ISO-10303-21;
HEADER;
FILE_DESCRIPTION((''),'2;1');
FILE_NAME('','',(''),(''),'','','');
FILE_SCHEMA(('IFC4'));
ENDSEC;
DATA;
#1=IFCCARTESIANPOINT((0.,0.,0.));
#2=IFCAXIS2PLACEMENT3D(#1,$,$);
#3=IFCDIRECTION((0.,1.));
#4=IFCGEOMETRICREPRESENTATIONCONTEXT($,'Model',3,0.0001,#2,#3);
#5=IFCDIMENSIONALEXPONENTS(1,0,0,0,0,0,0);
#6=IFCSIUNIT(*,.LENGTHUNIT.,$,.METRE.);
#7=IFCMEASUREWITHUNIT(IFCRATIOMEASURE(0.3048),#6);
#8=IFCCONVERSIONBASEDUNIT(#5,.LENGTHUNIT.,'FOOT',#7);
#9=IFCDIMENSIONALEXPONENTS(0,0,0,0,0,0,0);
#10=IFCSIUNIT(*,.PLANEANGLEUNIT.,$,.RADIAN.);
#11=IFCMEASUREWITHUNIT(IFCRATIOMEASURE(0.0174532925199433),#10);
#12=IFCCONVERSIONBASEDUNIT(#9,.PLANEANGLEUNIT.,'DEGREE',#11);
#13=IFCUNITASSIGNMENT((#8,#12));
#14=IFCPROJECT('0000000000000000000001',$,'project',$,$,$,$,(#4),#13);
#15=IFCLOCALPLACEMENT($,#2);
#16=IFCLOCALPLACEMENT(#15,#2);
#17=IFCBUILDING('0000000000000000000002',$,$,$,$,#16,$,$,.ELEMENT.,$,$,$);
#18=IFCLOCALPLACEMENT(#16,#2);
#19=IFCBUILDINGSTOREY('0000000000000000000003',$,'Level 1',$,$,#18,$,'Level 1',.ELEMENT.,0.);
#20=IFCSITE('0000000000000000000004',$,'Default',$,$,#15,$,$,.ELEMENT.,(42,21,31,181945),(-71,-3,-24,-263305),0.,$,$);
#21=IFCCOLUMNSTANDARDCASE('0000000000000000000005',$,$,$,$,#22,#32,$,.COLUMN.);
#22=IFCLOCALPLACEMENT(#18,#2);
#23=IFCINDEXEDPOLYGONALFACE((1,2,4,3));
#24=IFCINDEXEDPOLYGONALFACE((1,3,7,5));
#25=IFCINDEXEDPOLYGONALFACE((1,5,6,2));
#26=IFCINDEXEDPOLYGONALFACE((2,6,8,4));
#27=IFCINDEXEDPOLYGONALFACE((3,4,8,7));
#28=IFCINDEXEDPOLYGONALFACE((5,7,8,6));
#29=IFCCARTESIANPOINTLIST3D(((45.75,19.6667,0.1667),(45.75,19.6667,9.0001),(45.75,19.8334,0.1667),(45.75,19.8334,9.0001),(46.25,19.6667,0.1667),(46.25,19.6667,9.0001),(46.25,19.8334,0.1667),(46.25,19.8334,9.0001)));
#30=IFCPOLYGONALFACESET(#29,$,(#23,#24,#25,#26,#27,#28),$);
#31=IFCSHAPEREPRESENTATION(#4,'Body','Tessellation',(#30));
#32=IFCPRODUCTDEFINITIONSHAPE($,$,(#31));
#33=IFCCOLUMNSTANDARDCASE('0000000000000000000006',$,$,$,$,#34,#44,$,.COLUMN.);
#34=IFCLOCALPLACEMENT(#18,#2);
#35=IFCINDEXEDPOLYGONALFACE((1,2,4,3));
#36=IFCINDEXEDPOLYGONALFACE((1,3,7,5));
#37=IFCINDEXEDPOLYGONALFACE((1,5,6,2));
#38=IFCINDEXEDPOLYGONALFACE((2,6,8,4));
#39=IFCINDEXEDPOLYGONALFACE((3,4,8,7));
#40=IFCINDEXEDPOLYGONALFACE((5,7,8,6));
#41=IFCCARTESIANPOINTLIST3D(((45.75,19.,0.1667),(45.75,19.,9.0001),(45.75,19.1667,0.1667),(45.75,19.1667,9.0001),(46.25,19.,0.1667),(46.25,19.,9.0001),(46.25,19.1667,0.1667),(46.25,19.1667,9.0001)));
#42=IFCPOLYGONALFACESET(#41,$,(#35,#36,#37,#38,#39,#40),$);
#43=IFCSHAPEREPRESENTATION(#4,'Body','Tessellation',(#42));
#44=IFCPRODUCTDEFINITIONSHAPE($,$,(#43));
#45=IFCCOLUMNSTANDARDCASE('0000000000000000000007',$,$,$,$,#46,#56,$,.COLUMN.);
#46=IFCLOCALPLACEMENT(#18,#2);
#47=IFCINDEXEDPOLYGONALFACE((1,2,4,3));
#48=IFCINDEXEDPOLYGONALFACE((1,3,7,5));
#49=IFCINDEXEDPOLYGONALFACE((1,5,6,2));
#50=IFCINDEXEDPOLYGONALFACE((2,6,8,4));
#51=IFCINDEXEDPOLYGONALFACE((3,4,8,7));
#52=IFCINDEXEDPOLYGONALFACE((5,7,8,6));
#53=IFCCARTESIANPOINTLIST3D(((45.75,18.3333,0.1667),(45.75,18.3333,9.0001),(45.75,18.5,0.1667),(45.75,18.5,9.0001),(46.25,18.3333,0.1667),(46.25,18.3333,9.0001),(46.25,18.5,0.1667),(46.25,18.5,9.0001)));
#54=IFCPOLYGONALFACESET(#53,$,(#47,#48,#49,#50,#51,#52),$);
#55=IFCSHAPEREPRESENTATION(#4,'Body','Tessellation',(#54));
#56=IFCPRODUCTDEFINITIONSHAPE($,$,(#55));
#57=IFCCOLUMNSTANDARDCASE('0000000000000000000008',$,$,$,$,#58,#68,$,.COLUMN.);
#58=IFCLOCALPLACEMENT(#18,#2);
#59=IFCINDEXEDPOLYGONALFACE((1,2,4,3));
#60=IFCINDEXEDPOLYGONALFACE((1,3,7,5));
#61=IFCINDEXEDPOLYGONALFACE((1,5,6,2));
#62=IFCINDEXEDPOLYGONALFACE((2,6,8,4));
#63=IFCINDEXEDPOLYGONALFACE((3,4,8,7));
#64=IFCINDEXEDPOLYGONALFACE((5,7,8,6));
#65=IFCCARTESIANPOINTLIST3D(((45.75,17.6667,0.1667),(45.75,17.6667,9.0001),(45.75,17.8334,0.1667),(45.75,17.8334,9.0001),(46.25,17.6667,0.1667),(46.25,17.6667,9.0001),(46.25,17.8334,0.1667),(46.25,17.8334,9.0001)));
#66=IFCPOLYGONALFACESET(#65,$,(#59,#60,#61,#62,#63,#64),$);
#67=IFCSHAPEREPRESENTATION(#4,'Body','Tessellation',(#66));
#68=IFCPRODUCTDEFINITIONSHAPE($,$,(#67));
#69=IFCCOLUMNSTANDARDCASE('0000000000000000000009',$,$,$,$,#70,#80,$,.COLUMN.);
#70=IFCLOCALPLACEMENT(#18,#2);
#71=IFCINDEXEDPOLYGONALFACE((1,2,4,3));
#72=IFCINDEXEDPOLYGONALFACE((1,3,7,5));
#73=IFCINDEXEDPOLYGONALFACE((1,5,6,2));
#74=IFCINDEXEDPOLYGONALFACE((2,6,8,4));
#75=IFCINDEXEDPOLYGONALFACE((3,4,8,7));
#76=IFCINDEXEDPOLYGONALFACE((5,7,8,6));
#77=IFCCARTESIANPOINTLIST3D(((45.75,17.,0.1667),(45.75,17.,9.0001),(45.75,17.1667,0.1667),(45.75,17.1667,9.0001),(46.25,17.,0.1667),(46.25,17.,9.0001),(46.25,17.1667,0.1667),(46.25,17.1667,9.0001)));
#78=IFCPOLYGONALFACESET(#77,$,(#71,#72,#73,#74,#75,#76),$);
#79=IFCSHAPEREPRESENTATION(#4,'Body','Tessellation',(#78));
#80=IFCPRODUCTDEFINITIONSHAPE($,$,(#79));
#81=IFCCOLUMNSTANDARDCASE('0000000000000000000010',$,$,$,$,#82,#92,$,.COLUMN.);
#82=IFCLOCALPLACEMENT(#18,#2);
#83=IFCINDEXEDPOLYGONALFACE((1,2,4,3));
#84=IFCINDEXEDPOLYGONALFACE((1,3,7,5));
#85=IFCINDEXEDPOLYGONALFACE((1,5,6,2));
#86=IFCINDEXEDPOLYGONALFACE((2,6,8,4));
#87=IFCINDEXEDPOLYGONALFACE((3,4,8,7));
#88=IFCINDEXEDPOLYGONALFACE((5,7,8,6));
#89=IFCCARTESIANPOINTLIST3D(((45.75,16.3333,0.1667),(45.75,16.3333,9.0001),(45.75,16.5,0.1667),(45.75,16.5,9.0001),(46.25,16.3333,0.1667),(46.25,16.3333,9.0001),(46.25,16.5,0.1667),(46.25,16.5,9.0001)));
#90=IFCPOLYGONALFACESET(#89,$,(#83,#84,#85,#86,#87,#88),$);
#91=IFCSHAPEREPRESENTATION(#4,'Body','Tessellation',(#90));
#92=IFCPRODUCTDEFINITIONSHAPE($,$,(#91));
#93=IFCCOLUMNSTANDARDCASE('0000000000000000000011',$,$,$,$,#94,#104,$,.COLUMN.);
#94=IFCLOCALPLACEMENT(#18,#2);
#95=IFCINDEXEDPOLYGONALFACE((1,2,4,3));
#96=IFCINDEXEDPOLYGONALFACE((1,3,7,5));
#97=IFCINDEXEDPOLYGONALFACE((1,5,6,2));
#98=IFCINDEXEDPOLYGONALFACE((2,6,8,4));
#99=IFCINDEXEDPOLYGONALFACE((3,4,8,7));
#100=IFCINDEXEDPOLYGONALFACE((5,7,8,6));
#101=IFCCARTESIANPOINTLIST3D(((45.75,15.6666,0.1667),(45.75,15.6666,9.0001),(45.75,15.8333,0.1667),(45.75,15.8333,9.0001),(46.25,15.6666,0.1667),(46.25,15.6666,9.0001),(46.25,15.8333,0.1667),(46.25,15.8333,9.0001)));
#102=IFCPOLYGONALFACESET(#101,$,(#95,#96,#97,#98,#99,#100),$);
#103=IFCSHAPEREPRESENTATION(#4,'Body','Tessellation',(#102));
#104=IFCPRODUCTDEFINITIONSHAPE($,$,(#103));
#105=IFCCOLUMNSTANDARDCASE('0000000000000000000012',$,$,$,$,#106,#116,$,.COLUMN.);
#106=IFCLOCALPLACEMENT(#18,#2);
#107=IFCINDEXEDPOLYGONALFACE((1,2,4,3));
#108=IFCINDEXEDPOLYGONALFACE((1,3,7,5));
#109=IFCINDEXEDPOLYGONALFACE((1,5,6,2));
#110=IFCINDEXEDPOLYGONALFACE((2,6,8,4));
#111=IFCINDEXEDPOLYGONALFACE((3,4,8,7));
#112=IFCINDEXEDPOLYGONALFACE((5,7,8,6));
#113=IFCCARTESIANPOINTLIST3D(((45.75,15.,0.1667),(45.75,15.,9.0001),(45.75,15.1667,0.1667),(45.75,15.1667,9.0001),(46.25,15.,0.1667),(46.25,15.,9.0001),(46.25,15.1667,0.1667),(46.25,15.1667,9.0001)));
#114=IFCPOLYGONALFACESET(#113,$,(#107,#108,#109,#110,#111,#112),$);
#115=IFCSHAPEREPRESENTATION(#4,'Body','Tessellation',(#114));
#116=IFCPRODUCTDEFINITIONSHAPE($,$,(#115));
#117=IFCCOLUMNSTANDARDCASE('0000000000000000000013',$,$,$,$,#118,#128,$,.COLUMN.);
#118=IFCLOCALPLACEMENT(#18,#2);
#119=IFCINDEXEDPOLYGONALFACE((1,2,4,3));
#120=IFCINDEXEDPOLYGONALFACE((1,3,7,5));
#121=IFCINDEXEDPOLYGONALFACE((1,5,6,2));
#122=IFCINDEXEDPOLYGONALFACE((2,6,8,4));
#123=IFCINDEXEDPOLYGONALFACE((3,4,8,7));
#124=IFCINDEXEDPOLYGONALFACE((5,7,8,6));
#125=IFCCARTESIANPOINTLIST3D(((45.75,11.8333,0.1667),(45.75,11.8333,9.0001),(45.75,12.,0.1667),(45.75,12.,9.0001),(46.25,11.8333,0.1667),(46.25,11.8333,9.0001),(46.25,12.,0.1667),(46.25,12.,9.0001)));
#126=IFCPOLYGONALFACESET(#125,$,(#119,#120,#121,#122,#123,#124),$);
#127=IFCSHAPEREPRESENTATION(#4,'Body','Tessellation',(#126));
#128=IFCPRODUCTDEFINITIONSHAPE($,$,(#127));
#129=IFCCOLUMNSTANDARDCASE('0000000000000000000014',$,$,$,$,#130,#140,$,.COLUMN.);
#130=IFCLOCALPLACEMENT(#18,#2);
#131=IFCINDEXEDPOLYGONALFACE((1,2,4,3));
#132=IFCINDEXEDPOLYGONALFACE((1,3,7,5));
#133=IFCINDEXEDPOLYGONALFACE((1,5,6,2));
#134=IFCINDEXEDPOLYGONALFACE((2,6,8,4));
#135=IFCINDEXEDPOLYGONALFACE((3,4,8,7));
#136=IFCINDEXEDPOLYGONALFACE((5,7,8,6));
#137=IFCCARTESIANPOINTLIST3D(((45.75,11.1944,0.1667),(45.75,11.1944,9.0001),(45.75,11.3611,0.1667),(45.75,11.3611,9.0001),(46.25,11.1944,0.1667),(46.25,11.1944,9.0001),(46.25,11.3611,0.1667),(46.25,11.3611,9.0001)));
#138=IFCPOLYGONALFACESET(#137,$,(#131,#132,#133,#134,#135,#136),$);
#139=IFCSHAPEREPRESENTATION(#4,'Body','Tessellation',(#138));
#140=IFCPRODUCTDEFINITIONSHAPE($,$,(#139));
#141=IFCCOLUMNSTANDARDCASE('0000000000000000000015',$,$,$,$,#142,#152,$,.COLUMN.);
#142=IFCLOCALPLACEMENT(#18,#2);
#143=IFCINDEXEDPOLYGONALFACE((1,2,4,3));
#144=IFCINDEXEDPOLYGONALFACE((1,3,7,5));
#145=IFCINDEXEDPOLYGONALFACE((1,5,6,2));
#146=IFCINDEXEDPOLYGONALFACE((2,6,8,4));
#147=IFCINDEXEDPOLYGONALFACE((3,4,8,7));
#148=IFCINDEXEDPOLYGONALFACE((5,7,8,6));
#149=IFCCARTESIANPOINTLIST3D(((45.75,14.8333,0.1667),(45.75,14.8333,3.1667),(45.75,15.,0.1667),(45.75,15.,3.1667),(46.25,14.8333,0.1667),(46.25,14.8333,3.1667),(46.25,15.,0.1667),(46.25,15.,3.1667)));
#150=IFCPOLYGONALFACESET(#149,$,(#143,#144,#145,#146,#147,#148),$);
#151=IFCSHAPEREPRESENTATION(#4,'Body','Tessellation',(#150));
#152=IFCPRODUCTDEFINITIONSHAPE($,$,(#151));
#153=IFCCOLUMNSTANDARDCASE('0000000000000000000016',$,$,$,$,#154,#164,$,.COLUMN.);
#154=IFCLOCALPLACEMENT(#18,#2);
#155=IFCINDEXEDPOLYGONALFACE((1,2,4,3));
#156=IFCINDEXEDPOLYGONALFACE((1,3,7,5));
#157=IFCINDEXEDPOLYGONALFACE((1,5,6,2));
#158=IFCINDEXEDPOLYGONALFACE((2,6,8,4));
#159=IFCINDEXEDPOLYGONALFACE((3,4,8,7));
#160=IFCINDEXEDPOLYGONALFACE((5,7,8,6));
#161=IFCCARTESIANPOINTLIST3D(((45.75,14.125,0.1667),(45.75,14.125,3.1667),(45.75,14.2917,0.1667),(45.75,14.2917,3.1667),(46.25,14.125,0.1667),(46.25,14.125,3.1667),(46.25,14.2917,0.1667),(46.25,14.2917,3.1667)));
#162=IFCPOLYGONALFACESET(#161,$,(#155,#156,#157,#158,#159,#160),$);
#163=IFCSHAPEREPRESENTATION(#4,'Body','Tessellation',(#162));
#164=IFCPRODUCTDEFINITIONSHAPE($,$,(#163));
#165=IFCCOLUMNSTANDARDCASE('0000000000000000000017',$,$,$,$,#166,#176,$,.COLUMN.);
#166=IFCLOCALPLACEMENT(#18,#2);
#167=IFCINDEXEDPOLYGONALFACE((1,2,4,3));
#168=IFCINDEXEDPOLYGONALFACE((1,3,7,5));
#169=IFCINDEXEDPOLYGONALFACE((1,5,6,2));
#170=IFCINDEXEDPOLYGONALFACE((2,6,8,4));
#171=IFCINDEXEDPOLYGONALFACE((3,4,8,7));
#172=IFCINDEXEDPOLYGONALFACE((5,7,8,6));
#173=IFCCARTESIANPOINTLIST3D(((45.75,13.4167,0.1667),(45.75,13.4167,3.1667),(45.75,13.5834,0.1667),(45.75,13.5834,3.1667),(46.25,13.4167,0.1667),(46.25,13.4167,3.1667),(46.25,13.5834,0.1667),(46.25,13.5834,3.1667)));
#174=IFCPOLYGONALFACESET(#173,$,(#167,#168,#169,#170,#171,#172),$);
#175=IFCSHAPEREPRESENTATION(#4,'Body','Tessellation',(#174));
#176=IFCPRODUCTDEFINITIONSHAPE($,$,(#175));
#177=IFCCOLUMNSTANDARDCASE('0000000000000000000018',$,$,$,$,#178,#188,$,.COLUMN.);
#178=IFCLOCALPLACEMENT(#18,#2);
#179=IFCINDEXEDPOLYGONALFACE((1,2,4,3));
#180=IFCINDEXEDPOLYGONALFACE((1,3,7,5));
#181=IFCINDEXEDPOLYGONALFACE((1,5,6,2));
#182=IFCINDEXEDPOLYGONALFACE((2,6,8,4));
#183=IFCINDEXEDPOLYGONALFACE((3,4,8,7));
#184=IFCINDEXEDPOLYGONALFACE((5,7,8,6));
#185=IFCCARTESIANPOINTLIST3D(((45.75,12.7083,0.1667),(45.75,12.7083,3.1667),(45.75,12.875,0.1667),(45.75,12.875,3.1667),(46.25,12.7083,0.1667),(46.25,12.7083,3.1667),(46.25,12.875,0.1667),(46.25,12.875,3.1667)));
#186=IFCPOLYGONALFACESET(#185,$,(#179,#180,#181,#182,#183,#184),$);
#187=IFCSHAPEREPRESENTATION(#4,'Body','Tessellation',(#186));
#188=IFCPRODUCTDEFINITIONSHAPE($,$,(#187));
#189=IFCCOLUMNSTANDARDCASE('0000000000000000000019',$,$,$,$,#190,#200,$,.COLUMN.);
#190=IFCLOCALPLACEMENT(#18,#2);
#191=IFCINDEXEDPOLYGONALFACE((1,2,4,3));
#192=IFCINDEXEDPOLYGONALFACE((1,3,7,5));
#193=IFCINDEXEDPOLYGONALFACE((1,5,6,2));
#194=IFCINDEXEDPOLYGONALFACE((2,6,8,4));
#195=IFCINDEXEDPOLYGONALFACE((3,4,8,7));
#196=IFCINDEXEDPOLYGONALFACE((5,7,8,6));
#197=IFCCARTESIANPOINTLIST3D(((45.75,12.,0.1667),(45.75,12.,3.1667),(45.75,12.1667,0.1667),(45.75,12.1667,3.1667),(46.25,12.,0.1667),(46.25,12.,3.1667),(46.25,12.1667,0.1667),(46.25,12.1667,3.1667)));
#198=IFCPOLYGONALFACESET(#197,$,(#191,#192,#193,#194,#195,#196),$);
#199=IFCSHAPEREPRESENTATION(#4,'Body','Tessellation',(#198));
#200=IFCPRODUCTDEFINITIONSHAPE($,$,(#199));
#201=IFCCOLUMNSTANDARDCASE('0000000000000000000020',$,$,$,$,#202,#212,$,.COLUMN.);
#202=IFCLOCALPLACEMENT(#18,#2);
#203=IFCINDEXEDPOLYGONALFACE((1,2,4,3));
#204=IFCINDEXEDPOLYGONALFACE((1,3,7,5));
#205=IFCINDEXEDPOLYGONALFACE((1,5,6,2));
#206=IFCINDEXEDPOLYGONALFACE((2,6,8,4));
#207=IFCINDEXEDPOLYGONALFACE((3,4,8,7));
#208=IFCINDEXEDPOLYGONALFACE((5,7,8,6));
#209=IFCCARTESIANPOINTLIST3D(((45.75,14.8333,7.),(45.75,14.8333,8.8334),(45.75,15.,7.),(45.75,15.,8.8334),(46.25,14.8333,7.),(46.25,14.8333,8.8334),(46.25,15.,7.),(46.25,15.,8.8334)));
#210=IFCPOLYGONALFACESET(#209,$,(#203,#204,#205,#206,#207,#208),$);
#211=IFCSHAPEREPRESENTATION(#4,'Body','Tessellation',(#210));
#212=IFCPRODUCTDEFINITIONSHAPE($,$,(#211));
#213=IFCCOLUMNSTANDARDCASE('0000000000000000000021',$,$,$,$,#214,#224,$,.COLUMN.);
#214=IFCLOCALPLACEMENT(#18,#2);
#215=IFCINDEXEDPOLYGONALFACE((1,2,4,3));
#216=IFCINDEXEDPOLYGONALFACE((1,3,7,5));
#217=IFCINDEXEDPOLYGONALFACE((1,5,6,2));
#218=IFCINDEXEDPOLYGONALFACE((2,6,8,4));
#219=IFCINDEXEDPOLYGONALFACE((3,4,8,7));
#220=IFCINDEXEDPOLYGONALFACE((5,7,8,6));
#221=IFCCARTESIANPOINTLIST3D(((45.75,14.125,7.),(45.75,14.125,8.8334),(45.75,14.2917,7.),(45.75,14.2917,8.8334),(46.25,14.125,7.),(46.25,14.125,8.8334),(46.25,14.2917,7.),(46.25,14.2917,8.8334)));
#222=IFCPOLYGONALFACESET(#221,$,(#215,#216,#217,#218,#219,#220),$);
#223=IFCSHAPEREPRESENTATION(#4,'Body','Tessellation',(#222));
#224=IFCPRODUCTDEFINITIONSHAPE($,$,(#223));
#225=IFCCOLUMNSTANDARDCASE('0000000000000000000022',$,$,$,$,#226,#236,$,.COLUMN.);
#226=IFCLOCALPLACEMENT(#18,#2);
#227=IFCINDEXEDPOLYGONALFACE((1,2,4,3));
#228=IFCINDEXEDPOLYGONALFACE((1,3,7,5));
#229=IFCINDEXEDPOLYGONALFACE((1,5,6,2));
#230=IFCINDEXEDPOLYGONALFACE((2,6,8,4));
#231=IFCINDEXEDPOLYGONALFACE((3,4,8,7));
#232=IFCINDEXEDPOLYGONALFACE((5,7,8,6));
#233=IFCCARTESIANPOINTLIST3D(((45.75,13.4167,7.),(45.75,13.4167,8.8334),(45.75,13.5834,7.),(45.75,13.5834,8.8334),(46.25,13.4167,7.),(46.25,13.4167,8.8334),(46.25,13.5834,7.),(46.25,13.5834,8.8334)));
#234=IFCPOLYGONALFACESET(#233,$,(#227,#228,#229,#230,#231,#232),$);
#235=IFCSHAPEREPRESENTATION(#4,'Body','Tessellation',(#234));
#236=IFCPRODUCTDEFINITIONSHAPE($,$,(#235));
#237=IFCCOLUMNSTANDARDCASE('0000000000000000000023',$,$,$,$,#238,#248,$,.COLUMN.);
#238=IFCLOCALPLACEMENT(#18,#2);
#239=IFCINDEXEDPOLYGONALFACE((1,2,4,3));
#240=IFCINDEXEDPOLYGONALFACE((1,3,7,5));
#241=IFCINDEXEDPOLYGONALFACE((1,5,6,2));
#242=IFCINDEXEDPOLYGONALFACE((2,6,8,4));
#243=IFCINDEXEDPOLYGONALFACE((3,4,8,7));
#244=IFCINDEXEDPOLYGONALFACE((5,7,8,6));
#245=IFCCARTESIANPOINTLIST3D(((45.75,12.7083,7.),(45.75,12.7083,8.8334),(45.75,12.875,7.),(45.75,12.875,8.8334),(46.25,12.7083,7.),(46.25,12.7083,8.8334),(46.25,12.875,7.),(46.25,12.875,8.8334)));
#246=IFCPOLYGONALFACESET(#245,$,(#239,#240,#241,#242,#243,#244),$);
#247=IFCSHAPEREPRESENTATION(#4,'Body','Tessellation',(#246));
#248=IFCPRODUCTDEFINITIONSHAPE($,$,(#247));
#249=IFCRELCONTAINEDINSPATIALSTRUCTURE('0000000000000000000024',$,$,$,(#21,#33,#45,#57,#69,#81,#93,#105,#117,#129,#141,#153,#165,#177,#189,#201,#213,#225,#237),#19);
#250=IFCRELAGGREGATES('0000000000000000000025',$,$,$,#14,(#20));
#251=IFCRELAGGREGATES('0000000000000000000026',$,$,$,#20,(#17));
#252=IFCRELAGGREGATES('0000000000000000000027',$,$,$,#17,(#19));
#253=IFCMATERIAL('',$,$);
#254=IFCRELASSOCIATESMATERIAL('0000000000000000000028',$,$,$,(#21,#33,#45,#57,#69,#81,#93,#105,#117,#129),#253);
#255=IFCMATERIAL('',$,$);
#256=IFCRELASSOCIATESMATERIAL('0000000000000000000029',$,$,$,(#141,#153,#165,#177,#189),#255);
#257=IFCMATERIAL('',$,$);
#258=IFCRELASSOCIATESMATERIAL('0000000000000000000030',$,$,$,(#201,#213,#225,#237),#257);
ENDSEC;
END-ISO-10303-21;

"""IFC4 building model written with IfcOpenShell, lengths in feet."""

from ifc_helpers import new_model, entity, si_unit, converted_unit, direction, frame, origin, place, context, project, spatial, rectangle, extrude, material, element, save


model = new_model("IFC4")

# Units and contexts
model_context = context("Model", 3, precision=0.0001, world=origin(), true_north=direction((0.0, 1.0)))
ifc_project = project(units=[converted_unit("LENGTHUNIT", "FOOT", entity("IfcRatioMeasure", 0.3048), si_unit("LENGTHUNIT", "METRE"), dimensions=[1, 0, 0, 0, 0, 0, 0]), converted_unit("PLANEANGLEUNIT", "DEGREE", entity("IfcRatioMeasure", 0.0174532925199433), si_unit("PLANEANGLEUNIT", "RADIAN"), dimensions=[0, 0, 0, 0, 0, 0, 0])], contexts=[model_context])

# Site, building, storey
site_placement = place(None, origin())
site = spatial("IfcSite", under=ifc_project, at=site_placement, Name="Default", CompositionType="ELEMENT", RefLatitude=(42, 21, 31, 181945), RefLongitude=(-71, -3, -24, -263305), RefElevation=0.0)
building_placement = place(site_placement, origin())
building = spatial("IfcBuilding", under=site, at=building_placement, CompositionType="ELEMENT")
storey_placement = place(building_placement, origin())
storey = spatial("IfcBuildingStorey", under=building, at=storey_placement, Name="Level 1", LongName="Level 1", CompositionType="ELEMENT", Elevation=0.0)

# Columns
ifc_material_1 = material(Name="")
placement_1 = place(storey_placement, frame((46.0, 46.25, 0.0), z_axis=(0.0, 0.0, 1.0), x_axis=(0.0, -1.0, 0.0)))
for number, where, z_axis, x_axis in (
    (1, (26.5, 0.0, 0.1667), (0.0, 0.0, 1.0), (1.0, 0.0, 0.0)),
    (2, (27.1667, 0.0, 0.1667), (0.0, 0.0, 1.0), (1.0, 0.0, 0.0)),
    (3, (27.8334, 0.0, 0.1667), (0.0, 0.0, 1.0), (1.0, 0.0, 0.0)),
    (4, (28.5, 0.0, 0.1667), (0.0, 0.0, 1.0), (1.0, 0.0, 0.0)),
    (5, (29.1667, 0.0, 0.1667), (0.0, 0.0, 1.0), (1.0, 0.0, 0.0)),
    (6, (29.8334, 0.0, 0.1667), (0.0, 0.0, 1.0), (1.0, 0.0, 0.0)),
    (7, (30.5001, 0.0, 0.1667), (0.0, 0.0, 1.0), (1.0, 0.0, 0.0)),
    (8, (31.1667, 0.0, 0.1667), (0.0, 0.0, 1.0), (1.0, 0.0, 0.0)),
    (9, (34.3334, 0.0, 0.1667), (0.0, 0.0, 1.0), (1.0, 0.0, 0.0)),
    (10, (34.9723, 0.0, 0.1667), (0.0, 0.0, 1.0), (1.0, 0.0, 0.0)),
):
    element("IfcColumnStandardCase", number, at=place(placement_1, frame(where, z_axis=z_axis, x_axis=x_axis)), inside=storey, material=ifc_material_1, PredefinedType="COLUMN", context=model_context, shape_type="SweptSolid", body=[
        extrude(rectangle(XDim=0.1667, YDim=0.5), origin(), (0.0, 0.0, 1.0), 8.8334),
    ])
ifc_material_2 = material(Name="")
for number, where, z_axis, x_axis in (
    (11, (31.3334, 0.0, 0.1667), (0.0, 0.0, 1.0), (1.0, 0.0, 0.0)),
    (12, (32.0417, 0.0, 0.1667), (0.0, 0.0, 1.0), (1.0, 0.0, 0.0)),
    (13, (32.75, 0.0, 0.1667), (0.0, 0.0, 1.0), (1.0, 0.0, 0.0)),
    (14, (33.4584, 0.0, 0.1667), (0.0, 0.0, 1.0), (1.0, 0.0, 0.0)),
    (15, (34.1667, 0.0, 0.1667), (0.0, 0.0, 1.0), (1.0, 0.0, 0.0)),
):
    element("IfcColumnStandardCase", number, at=place(placement_1, frame(where, z_axis=z_axis, x_axis=x_axis)), inside=storey, material=ifc_material_2, PredefinedType="COLUMN", context=model_context, shape_type="SweptSolid", body=[
        extrude(rectangle(XDim=0.1667, YDim=0.5), origin(), (0.0, 0.0, 1.0), 3.0),
    ])
ifc_material_3 = material(Name="")
for number, where, z_axis, x_axis in (
    (16, (31.3334, 0.0, 7.0), (0.0, 0.0, 1.0), (1.0, 0.0, 0.0)),
    (17, (32.0417, 0.0, 7.0), (0.0, 0.0, 1.0), (1.0, 0.0, 0.0)),
    (18, (32.75, 0.0, 7.0), (0.0, 0.0, 1.0), (1.0, 0.0, 0.0)),
    (19, (33.4584, 0.0, 7.0), (0.0, 0.0, 1.0), (1.0, 0.0, 0.0)),
):
    element("IfcColumnStandardCase", number, at=place(placement_1, frame(where, z_axis=z_axis, x_axis=x_axis)), inside=storey, material=ifc_material_3, PredefinedType="COLUMN", context=model_context, shape_type="SweptSolid", body=[
        extrude(rectangle(XDim=0.1667, YDim=0.5), origin(), (0.0, 0.0, 1.0), 1.8334),
    ])

save(model, "model.ifc")
